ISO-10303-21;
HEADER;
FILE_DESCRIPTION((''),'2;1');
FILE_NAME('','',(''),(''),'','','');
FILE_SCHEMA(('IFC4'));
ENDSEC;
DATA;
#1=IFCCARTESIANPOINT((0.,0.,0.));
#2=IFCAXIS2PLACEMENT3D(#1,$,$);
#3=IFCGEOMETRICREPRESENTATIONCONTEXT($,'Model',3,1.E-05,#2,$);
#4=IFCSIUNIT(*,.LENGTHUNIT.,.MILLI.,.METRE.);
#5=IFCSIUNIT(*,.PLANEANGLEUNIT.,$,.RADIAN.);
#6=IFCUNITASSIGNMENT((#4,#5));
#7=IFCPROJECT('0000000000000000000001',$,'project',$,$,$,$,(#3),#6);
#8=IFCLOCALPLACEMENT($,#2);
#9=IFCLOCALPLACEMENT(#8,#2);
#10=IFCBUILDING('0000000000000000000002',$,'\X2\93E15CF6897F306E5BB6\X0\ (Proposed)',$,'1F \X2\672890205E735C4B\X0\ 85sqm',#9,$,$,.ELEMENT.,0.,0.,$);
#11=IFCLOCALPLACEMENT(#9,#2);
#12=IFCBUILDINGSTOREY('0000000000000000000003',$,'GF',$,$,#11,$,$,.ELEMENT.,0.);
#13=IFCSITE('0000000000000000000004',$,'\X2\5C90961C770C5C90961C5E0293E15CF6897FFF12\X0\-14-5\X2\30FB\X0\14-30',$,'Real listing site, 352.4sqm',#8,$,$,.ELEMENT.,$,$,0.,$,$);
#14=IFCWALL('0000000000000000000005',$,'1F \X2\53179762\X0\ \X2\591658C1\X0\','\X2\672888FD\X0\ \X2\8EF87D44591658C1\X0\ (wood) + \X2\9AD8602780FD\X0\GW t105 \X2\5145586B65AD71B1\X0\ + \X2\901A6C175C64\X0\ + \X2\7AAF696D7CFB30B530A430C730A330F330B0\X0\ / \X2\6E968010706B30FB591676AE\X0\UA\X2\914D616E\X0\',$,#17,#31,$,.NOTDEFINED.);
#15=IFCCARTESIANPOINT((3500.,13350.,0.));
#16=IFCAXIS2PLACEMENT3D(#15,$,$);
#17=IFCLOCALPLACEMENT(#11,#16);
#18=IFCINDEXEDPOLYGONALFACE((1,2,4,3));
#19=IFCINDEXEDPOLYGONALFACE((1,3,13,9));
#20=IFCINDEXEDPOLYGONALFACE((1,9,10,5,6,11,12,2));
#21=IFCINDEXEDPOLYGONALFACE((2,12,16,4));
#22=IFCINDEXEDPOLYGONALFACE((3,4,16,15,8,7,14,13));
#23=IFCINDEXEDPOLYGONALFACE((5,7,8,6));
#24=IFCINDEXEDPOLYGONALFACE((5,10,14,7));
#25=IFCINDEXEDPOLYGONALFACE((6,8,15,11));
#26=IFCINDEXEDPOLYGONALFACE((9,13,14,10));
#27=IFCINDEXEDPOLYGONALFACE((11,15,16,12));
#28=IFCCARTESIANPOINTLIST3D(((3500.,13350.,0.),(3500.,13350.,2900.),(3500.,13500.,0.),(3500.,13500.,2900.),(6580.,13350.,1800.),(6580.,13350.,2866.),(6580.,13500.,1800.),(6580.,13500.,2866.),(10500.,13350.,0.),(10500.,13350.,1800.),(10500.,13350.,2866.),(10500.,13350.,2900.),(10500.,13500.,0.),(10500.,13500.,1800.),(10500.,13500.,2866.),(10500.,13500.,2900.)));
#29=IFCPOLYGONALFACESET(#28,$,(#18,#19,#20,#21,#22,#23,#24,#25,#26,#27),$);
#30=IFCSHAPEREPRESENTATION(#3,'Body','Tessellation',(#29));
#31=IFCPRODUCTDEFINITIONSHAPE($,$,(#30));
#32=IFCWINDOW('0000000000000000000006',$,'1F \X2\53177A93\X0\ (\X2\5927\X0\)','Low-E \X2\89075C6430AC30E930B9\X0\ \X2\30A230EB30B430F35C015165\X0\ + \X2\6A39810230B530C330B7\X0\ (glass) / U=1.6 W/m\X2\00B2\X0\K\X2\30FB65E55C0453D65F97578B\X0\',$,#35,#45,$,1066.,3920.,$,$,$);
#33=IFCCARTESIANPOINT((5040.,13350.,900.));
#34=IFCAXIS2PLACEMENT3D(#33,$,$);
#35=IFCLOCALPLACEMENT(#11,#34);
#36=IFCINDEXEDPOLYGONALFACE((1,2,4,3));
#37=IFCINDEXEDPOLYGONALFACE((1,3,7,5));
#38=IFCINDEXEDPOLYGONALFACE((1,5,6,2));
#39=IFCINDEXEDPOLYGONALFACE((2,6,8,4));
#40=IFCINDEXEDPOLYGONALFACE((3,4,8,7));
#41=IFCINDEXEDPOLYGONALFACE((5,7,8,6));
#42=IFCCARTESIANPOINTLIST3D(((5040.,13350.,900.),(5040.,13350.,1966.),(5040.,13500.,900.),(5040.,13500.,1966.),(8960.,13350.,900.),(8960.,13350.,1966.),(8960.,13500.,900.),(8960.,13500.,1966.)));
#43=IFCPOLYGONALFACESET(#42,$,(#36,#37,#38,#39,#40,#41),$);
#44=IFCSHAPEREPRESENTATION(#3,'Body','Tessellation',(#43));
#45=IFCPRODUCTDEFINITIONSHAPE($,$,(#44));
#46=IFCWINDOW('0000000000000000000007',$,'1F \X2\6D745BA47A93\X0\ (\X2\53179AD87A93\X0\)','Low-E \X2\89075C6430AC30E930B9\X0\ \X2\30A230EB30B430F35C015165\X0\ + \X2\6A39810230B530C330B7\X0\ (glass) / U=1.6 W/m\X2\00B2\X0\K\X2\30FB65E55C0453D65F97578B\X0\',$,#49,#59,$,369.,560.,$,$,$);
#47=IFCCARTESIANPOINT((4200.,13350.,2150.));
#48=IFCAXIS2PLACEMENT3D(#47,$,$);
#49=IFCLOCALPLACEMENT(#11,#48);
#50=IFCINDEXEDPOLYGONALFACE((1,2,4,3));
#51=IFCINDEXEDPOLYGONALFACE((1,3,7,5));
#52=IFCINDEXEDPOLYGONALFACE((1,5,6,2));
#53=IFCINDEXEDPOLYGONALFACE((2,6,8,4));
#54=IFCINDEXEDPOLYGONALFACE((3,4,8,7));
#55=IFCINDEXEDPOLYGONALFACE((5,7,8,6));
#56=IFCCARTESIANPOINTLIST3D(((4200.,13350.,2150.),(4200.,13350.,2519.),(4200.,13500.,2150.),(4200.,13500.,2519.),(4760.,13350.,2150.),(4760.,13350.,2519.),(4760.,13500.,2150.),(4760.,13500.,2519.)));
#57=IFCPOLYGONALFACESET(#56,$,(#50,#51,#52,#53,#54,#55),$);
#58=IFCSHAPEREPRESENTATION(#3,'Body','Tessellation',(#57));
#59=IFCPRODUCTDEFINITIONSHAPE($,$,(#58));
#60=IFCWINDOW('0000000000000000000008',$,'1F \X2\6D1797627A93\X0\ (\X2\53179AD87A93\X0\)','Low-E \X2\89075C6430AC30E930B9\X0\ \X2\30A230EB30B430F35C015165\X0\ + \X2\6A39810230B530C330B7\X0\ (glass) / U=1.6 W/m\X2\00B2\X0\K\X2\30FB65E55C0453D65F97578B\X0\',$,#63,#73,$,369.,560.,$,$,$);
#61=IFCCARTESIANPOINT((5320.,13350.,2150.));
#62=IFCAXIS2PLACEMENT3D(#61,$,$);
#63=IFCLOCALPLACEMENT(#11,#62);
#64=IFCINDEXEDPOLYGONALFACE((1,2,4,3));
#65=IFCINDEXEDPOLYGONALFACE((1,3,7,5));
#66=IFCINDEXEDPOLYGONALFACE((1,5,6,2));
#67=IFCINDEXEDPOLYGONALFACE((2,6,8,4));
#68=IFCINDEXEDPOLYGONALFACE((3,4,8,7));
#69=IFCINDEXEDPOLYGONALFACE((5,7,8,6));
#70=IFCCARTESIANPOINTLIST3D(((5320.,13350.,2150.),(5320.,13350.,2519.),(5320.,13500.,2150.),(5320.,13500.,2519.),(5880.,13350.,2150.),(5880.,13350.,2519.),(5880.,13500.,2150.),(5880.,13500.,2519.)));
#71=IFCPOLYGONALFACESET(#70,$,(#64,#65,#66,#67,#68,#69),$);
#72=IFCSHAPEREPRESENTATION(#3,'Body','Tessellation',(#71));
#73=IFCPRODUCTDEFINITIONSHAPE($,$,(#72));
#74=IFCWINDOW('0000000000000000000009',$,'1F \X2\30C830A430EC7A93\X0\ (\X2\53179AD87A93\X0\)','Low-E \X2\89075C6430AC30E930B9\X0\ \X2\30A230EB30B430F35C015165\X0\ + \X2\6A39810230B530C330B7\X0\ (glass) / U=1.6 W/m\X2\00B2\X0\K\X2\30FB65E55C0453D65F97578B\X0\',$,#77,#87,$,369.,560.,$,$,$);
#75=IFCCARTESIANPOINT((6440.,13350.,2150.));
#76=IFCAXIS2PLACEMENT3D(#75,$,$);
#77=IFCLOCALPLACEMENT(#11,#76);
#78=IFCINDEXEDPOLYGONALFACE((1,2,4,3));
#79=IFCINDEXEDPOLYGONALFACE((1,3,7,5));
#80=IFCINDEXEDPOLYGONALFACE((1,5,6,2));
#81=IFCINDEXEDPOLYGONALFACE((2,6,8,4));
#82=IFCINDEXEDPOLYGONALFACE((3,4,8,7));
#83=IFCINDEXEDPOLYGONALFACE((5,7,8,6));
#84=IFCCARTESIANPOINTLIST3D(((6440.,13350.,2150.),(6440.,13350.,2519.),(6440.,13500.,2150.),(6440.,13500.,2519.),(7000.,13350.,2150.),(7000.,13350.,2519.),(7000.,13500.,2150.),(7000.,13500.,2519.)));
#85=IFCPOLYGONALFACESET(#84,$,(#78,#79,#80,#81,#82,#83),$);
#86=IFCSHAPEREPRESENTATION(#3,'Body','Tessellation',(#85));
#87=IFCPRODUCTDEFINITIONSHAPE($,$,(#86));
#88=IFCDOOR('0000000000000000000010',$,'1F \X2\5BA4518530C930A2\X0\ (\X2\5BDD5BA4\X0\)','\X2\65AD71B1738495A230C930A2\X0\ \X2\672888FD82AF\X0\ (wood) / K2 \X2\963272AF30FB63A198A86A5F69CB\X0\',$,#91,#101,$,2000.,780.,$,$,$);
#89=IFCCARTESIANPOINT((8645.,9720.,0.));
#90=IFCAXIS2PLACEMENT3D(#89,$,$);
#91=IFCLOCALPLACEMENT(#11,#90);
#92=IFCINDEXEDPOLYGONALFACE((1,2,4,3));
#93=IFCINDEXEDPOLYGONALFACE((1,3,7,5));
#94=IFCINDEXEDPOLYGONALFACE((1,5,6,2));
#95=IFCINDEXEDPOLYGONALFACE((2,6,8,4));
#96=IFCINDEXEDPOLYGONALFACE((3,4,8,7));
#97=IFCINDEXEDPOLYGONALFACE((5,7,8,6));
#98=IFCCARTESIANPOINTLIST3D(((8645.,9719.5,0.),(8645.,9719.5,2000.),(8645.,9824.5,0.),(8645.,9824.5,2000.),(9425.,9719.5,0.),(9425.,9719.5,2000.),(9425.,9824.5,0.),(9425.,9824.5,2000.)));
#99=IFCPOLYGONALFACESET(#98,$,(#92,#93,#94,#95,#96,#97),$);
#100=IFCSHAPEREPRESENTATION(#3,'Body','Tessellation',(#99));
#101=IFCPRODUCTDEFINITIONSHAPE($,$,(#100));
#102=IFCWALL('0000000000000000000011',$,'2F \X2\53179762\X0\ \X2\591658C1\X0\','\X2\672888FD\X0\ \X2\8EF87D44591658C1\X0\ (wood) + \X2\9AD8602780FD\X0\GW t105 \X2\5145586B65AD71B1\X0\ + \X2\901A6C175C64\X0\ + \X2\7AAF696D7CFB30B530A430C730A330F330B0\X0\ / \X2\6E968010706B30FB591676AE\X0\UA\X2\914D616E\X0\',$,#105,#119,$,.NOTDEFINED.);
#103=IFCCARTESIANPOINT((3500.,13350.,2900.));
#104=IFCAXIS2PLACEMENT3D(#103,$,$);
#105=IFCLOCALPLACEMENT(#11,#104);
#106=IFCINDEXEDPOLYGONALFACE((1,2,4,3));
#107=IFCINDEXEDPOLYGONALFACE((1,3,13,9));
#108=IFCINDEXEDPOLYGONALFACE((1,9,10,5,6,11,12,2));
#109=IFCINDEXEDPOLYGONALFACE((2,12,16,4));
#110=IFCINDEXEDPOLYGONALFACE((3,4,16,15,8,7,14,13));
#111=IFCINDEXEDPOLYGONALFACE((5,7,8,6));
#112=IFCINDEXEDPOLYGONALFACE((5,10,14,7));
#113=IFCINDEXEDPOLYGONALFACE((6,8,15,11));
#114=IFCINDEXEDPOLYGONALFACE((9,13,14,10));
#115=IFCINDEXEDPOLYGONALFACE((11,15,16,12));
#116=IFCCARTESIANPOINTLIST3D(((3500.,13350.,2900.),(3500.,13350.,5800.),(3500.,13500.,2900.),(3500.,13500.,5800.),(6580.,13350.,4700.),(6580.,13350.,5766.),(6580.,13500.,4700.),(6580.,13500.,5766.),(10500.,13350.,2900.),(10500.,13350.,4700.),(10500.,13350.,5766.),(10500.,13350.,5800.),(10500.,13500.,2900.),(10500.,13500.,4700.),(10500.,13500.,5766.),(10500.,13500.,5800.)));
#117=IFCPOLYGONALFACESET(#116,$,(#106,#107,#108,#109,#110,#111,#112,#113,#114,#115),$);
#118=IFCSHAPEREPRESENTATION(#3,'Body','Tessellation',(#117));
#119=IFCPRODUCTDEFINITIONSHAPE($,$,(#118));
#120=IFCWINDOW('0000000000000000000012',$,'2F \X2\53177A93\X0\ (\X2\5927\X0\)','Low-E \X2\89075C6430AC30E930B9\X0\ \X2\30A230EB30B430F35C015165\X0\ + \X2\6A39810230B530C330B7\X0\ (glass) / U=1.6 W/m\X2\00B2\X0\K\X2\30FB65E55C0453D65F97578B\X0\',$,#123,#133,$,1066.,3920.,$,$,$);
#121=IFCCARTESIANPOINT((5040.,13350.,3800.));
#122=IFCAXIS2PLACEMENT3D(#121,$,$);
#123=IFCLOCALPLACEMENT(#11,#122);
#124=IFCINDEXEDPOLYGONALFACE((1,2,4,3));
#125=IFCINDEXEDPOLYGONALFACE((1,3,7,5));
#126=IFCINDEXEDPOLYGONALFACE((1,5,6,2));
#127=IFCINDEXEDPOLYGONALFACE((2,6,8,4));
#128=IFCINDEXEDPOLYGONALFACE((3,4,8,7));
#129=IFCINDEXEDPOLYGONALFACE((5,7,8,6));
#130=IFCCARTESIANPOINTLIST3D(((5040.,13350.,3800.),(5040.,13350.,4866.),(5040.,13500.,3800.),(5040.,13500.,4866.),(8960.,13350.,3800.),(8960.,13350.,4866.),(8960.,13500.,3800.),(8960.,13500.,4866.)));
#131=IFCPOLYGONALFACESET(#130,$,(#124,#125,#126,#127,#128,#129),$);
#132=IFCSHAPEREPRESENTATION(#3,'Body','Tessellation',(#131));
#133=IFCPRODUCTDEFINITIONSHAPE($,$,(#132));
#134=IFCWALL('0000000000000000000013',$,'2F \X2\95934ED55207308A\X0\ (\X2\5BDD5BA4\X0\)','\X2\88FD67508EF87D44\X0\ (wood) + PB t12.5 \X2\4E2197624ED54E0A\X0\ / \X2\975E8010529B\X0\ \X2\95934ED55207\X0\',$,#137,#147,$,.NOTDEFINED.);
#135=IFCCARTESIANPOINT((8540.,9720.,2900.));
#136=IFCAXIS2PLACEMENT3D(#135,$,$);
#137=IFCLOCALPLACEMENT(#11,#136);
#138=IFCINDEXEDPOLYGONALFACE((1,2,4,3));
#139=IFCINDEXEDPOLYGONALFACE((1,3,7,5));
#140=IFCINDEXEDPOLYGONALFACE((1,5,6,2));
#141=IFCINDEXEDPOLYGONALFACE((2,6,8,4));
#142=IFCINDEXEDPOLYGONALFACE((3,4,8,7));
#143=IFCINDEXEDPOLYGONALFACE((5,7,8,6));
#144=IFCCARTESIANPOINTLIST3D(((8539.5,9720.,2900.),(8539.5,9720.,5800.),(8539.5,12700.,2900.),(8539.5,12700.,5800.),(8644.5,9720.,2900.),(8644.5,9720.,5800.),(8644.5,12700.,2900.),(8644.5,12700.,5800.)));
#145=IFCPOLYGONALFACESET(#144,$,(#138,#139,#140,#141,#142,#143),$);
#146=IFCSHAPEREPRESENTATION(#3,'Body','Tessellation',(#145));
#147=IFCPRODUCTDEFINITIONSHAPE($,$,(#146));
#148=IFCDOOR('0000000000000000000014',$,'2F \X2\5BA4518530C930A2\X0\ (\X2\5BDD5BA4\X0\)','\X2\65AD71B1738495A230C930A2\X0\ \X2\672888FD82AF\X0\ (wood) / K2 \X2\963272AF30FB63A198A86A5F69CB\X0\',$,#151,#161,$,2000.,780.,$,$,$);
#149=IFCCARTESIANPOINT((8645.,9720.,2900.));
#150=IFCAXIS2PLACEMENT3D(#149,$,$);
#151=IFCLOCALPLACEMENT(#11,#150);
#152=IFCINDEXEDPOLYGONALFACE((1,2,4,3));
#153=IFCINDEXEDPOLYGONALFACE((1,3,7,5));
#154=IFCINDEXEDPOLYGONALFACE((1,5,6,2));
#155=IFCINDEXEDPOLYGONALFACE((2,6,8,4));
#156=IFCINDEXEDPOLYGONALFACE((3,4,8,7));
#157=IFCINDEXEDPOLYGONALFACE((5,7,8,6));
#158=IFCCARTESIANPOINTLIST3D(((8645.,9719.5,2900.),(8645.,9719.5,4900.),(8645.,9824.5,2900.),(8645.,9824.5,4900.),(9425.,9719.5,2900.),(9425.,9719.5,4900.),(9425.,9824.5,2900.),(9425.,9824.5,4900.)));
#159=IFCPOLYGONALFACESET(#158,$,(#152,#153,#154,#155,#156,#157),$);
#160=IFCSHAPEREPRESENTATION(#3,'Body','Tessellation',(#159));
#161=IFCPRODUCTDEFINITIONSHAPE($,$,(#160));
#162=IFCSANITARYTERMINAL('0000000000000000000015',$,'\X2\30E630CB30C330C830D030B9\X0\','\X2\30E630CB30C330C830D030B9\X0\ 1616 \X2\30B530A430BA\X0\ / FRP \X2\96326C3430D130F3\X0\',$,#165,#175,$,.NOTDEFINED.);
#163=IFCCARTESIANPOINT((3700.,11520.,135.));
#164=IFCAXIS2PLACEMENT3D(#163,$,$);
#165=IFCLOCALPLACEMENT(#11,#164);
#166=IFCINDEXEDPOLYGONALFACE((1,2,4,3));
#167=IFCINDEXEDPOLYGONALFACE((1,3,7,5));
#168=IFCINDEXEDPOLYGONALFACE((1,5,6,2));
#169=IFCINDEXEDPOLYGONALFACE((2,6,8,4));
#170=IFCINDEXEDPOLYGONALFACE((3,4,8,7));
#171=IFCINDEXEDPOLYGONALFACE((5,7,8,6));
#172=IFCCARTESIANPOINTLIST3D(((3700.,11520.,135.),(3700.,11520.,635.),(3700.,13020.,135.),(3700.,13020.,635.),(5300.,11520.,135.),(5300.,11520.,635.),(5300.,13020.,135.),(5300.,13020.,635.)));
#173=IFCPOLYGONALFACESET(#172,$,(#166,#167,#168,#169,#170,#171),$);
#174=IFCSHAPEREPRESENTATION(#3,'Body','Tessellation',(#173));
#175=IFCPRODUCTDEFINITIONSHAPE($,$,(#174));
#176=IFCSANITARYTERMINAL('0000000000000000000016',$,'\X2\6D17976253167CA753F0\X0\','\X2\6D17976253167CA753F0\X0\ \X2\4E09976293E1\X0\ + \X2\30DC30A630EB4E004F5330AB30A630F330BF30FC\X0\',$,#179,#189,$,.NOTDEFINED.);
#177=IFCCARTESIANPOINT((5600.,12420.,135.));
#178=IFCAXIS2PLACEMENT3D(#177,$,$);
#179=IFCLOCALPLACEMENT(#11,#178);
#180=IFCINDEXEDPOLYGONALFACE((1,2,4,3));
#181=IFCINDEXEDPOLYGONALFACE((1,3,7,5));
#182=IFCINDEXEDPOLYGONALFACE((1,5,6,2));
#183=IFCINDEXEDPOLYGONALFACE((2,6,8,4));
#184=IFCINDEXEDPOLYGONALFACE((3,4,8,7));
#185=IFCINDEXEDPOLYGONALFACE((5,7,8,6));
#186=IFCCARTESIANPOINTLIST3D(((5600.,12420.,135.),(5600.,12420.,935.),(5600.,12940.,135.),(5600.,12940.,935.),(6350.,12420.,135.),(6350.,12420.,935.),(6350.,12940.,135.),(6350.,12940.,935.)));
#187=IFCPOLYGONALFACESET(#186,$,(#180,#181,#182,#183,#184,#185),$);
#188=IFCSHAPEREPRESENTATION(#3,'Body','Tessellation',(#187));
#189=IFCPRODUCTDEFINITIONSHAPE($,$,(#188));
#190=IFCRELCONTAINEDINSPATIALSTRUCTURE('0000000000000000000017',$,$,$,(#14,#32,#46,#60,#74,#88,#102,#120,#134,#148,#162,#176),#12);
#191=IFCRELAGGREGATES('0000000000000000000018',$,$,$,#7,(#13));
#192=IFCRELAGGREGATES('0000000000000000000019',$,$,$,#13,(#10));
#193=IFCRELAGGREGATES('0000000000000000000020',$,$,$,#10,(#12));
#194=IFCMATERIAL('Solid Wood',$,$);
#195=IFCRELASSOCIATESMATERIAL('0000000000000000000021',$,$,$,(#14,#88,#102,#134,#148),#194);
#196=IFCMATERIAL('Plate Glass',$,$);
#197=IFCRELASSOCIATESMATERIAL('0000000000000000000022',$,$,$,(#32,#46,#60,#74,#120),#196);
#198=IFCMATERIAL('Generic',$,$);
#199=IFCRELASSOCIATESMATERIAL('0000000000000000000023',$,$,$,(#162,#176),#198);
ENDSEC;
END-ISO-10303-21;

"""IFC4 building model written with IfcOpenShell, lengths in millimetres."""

from ifc_helpers import new_model, si_unit, frame, frame_2d, origin, place, context, project, spatial, rectangle, extrude, material, element, fill, save


model = new_model("IFC4")

# Units and contexts
model_context = context("Model", 3, precision=1e-05, world=origin())
ifc_project = project(units=[si_unit("LENGTHUNIT", "METRE", prefix="MILLI"), si_unit("PLANEANGLEUNIT", "RADIAN")], contexts=[model_context])

# Site, building, storey
site_placement = place(None, origin())
site = spatial("IfcSite", under=ifc_project, at=site_placement, Name="岐阜県岐阜市鏡島西２-14-5・14-30", ObjectType="Real listing site, 352.4sqm", CompositionType="ELEMENT", RefElevation=0.0)
building_placement = place(site_placement, origin())
building = spatial("IfcBuilding", under=site, at=building_placement, Name="鏡島西の家 (Proposed)", ObjectType="1F 木造平屋 85sqm", CompositionType="ELEMENT", ElevationOfRefHeight=0.0, ElevationOfTerrain=0.0)
storey_placement = place(building_placement, origin())
storey = spatial("IfcBuildingStorey", under=building, at=storey_placement, Name="GF", CompositionType="ELEMENT", Elevation=0.0)

# Wall, openings, windows
ifc_material_1 = material(Name="Solid Wood")
wall_1_placement = place(storey_placement, frame((3500.0, 13350.0, 0.0)))
wall_1 = element("IfcWall", 1, at=wall_1_placement, inside=storey, material=ifc_material_1, Name="1F 北面 外壁", Description="木製 軸組外壁 (wood) + 高性能GW t105 充填断熱 + 通気層 + 窯業系サイディング / 準耐火・外皮UA配慮", PredefinedType="NOTDEFINED", context=model_context, shape_type="SweptSolid", body=[
    extrude(rectangle(XDim=7000.0, YDim=150.0, at=frame_2d((3500.0, 75.0))), frame((3500.0, 13350.0, 0.0)), (0.0, 0.0, 1.0), 2900.0),
])
opening_1_placement = place(storey_placement, frame((5040.0, 13350.0, 900.0)))
opening_1 = element("IfcOpeningElement", 2, at=opening_1_placement, cuts=wall_1, PredefinedType="NOTDEFINED", context=model_context, shape_type="SweptSolid", body=[
    extrude(rectangle(XDim=3920.0, YDim=150.0, at=frame_2d((1960.0, 75.0))), frame((5040.0, 13350.0, 900.0)), (0.0, 0.0, 1.0), 1066.0),
])
opening_2_placement = place(storey_placement, frame((4200.0, 13350.0, 2150.0)))
opening_2 = element("IfcOpeningElement", 3, at=opening_2_placement, cuts=wall_1, PredefinedType="NOTDEFINED", context=model_context, shape_type="SweptSolid", body=[
    extrude(rectangle(XDim=560.0, YDim=150.0, at=frame_2d((280.0, 75.0))), frame((4200.0, 13350.0, 2150.0)), (0.0, 0.0, 1.0), 369.0),
])
opening_3_placement = place(storey_placement, frame((5320.0, 13350.0, 2150.0)))
opening_3 = element("IfcOpeningElement", 4, at=opening_3_placement, cuts=wall_1, PredefinedType="NOTDEFINED", context=model_context, shape_type="SweptSolid", body=[
    extrude(rectangle(XDim=560.0, YDim=150.0, at=frame_2d((280.0, 75.0))), frame((5320.0, 13350.0, 2150.0)), (0.0, 0.0, 1.0), 369.0),
])
opening_4_placement = place(storey_placement, frame((6440.0, 13350.0, 2150.0)))
opening_4 = element("IfcOpeningElement", 5, at=opening_4_placement, cuts=wall_1, PredefinedType="NOTDEFINED", context=model_context, shape_type="SweptSolid", body=[
    extrude(rectangle(XDim=560.0, YDim=150.0, at=frame_2d((280.0, 75.0))), frame((6440.0, 13350.0, 2150.0)), (0.0, 0.0, 1.0), 369.0),
])
ifc_material_2 = material(Name="Plate Glass")
window_1_placement = place(storey_placement, frame((5040.0, 13350.0, 900.0)))
window_1 = element("IfcWindow", 6, at=window_1_placement, inside=storey, material=ifc_material_2, Name="1F 北窓 (大)", Description="Low-E 複層ガラス アルゴン封入 + 樹脂サッシ (glass) / U=1.6 W/m²K・日射取得型", OverallHeight=1066.0, OverallWidth=3920.0, context=model_context, shape_type="SweptSolid", body=[
    extrude(rectangle(XDim=3920.0, YDim=150.0, at=frame_2d((1960.0, 75.0))), frame((5040.0, 13350.0, 900.0)), (0.0, 0.0, 1.0), 1066.0),
])
fill(opening_1, window_1)
window_2_placement = place(storey_placement, frame((4200.0, 13350.0, 2150.0)))
window_2 = element("IfcWindow", 7, at=window_2_placement, inside=storey, material=ifc_material_2, Name="1F 浴室窓 (北高窓)", Description="Low-E 複層ガラス アルゴン封入 + 樹脂サッシ (glass) / U=1.6 W/m²K・日射取得型", OverallHeight=369.0, OverallWidth=560.0, context=model_context, shape_type="SweptSolid", body=[
    extrude(rectangle(XDim=560.0, YDim=150.0, at=frame_2d((280.0, 75.0))), frame((4200.0, 13350.0, 2150.0)), (0.0, 0.0, 1.0), 369.0),
])
fill(opening_2, window_2)
window_3_placement = place(storey_placement, frame((5320.0, 13350.0, 2150.0)))
window_3 = element("IfcWindow", 8, at=window_3_placement, inside=storey, material=ifc_material_2, Name="1F 洗面窓 (北高窓)", Description="Low-E 複層ガラス アルゴン封入 + 樹脂サッシ (glass) / U=1.6 W/m²K・日射取得型", OverallHeight=369.0, OverallWidth=560.0, context=model_context, shape_type="SweptSolid", body=[
    extrude(rectangle(XDim=560.0, YDim=150.0, at=frame_2d((280.0, 75.0))), frame((5320.0, 13350.0, 2150.0)), (0.0, 0.0, 1.0), 369.0),
])
fill(opening_3, window_3)
window_4_placement = place(storey_placement, frame((6440.0, 13350.0, 2150.0)))
window_4 = element("IfcWindow", 9, at=window_4_placement, inside=storey, material=ifc_material_2, Name="1F トイレ窓 (北高窓)", Description="Low-E 複層ガラス アルゴン封入 + 樹脂サッシ (glass) / U=1.6 W/m²K・日射取得型", OverallHeight=369.0, OverallWidth=560.0, context=model_context, shape_type="SweptSolid", body=[
    extrude(rectangle(XDim=560.0, YDim=150.0, at=frame_2d((280.0, 75.0))), frame((6440.0, 13350.0, 2150.0)), (0.0, 0.0, 1.0), 369.0),
])
fill(opening_4, window_4)

# Door
door_1_placement = place(storey_placement, frame((8645.0, 9720.0, 0.0)))
element("IfcDoor", 10, at=door_1_placement, inside=storey, material=ifc_material_1, Name="1F 室内ドア (寝室)", Description="断熱玄関ドア 木製芯 (wood) / K2 防犯・採風機構", OverallHeight=2000.0, OverallWidth=780.0, context=model_context, shape_type="SweptSolid", body=[
    extrude(rectangle(XDim=780.0, YDim=105.0, at=frame_2d((390.0, 52.0))), frame((8645.0, 9720.0, 0.0)), (0.0, 0.0, 1.0), 2000.0),
])

# Wall, opening, window
wall_2_placement = place(storey_placement, frame((3500.0, 13350.0, 2900.0)))
wall_2 = element("IfcWall", 11, at=wall_2_placement, inside=storey, material=ifc_material_1, Name="2F 北面 外壁", Description="木製 軸組外壁 (wood) + 高性能GW t105 充填断熱 + 通気層 + 窯業系サイディング / 準耐火・外皮UA配慮", PredefinedType="NOTDEFINED", context=model_context, shape_type="SweptSolid", body=[
    extrude(rectangle(XDim=7000.0, YDim=150.0, at=frame_2d((3500.0, 75.0))), frame((3500.0, 13350.0, 2900.0)), (0.0, 0.0, 1.0), 2900.0),
])
opening_5_placement = place(storey_placement, frame((5040.0, 13350.0, 3800.0)))
opening_5 = element("IfcOpeningElement", 12, at=opening_5_placement, cuts=wall_2, PredefinedType="NOTDEFINED", context=model_context, shape_type="SweptSolid", body=[
    extrude(rectangle(XDim=3920.0, YDim=150.0, at=frame_2d((1960.0, 75.0))), frame((5040.0, 13350.0, 3800.0)), (0.0, 0.0, 1.0), 1066.0),
])
window_5_placement = place(storey_placement, frame((5040.0, 13350.0, 3800.0)))
window_5 = element("IfcWindow", 13, at=window_5_placement, inside=storey, material=ifc_material_2, Name="2F 北窓 (大)", Description="Low-E 複層ガラス アルゴン封入 + 樹脂サッシ (glass) / U=1.6 W/m²K・日射取得型", OverallHeight=1066.0, OverallWidth=3920.0, context=model_context, shape_type="SweptSolid", body=[
    extrude(rectangle(XDim=3920.0, YDim=150.0, at=frame_2d((1960.0, 75.0))), frame((5040.0, 13350.0, 3800.0)), (0.0, 0.0, 1.0), 1066.0),
])
fill(opening_5, window_5)

# Wall
wall_3_placement = place(storey_placement, frame((8540.0, 9720.0, 2900.0)))
element("IfcWall", 14, at=wall_3_placement, inside=storey, material=ifc_material_1, Name="2F 間仕切り (寝室)", Description="製材軸組 (wood) + PB t12.5 両面仕上 / 非耐力 間仕切", PredefinedType="NOTDEFINED", context=model_context, shape_type="SweptSolid", body=[
    extrude(rectangle(XDim=105.0, YDim=2980.0, at=frame_2d((52.0, 1490.0))), frame((8540.0, 9720.0, 2900.0)), (0.0, 0.0, 1.0), 2900.0),
])

# Door
door_2_placement = place(storey_placement, frame((8645.0, 9720.0, 2900.0)))
element("IfcDoor", 15, at=door_2_placement, inside=storey, material=ifc_material_1, Name="2F 室内ドア (寝室)", Description="断熱玄関ドア 木製芯 (wood) / K2 防犯・採風機構", OverallHeight=2000.0, OverallWidth=780.0, context=model_context, shape_type="SweptSolid", body=[
    extrude(rectangle(XDim=780.0, YDim=105.0, at=frame_2d((390.0, 52.0))), frame((8645.0, 9720.0, 2900.0)), (0.0, 0.0, 1.0), 2000.0),
])

# Sanitary terminals
ifc_material_3 = material(Name="Generic")
sanitary_terminal_1_placement = place(storey_placement, frame((3700.0, 11520.0, 135.0)))
element("IfcSanitaryTerminal", 16, at=sanitary_terminal_1_placement, inside=storey, material=ifc_material_3, Name="ユニットバス", Description="ユニットバス 1616 サイズ / FRP 防水パン", PredefinedType="NOTDEFINED", context=model_context, shape_type="SweptSolid", body=[
    extrude(rectangle(XDim=1600.0, YDim=1500.0, at=frame_2d((800.0, 750.0))), frame((3700.0, 11520.0, 135.0)), (0.0, 0.0, 1.0), 500.0),
])
sanitary_terminal_2_placement = place(storey_placement, frame((5600.0, 12420.0, 135.0)))
element("IfcSanitaryTerminal", 17, at=sanitary_terminal_2_placement, inside=storey, material=ifc_material_3, Name="洗面化粧台", Description="洗面化粧台 三面鏡 + ボウル一体カウンター", PredefinedType="NOTDEFINED", context=model_context, shape_type="SweptSolid", body=[
    extrude(rectangle(XDim=750.0, YDim=520.0, at=frame_2d((375.0, 260.0))), frame((5600.0, 12420.0, 135.0)), (0.0, 0.0, 1.0), 800.0),
])

save(model, "model.ifc")
